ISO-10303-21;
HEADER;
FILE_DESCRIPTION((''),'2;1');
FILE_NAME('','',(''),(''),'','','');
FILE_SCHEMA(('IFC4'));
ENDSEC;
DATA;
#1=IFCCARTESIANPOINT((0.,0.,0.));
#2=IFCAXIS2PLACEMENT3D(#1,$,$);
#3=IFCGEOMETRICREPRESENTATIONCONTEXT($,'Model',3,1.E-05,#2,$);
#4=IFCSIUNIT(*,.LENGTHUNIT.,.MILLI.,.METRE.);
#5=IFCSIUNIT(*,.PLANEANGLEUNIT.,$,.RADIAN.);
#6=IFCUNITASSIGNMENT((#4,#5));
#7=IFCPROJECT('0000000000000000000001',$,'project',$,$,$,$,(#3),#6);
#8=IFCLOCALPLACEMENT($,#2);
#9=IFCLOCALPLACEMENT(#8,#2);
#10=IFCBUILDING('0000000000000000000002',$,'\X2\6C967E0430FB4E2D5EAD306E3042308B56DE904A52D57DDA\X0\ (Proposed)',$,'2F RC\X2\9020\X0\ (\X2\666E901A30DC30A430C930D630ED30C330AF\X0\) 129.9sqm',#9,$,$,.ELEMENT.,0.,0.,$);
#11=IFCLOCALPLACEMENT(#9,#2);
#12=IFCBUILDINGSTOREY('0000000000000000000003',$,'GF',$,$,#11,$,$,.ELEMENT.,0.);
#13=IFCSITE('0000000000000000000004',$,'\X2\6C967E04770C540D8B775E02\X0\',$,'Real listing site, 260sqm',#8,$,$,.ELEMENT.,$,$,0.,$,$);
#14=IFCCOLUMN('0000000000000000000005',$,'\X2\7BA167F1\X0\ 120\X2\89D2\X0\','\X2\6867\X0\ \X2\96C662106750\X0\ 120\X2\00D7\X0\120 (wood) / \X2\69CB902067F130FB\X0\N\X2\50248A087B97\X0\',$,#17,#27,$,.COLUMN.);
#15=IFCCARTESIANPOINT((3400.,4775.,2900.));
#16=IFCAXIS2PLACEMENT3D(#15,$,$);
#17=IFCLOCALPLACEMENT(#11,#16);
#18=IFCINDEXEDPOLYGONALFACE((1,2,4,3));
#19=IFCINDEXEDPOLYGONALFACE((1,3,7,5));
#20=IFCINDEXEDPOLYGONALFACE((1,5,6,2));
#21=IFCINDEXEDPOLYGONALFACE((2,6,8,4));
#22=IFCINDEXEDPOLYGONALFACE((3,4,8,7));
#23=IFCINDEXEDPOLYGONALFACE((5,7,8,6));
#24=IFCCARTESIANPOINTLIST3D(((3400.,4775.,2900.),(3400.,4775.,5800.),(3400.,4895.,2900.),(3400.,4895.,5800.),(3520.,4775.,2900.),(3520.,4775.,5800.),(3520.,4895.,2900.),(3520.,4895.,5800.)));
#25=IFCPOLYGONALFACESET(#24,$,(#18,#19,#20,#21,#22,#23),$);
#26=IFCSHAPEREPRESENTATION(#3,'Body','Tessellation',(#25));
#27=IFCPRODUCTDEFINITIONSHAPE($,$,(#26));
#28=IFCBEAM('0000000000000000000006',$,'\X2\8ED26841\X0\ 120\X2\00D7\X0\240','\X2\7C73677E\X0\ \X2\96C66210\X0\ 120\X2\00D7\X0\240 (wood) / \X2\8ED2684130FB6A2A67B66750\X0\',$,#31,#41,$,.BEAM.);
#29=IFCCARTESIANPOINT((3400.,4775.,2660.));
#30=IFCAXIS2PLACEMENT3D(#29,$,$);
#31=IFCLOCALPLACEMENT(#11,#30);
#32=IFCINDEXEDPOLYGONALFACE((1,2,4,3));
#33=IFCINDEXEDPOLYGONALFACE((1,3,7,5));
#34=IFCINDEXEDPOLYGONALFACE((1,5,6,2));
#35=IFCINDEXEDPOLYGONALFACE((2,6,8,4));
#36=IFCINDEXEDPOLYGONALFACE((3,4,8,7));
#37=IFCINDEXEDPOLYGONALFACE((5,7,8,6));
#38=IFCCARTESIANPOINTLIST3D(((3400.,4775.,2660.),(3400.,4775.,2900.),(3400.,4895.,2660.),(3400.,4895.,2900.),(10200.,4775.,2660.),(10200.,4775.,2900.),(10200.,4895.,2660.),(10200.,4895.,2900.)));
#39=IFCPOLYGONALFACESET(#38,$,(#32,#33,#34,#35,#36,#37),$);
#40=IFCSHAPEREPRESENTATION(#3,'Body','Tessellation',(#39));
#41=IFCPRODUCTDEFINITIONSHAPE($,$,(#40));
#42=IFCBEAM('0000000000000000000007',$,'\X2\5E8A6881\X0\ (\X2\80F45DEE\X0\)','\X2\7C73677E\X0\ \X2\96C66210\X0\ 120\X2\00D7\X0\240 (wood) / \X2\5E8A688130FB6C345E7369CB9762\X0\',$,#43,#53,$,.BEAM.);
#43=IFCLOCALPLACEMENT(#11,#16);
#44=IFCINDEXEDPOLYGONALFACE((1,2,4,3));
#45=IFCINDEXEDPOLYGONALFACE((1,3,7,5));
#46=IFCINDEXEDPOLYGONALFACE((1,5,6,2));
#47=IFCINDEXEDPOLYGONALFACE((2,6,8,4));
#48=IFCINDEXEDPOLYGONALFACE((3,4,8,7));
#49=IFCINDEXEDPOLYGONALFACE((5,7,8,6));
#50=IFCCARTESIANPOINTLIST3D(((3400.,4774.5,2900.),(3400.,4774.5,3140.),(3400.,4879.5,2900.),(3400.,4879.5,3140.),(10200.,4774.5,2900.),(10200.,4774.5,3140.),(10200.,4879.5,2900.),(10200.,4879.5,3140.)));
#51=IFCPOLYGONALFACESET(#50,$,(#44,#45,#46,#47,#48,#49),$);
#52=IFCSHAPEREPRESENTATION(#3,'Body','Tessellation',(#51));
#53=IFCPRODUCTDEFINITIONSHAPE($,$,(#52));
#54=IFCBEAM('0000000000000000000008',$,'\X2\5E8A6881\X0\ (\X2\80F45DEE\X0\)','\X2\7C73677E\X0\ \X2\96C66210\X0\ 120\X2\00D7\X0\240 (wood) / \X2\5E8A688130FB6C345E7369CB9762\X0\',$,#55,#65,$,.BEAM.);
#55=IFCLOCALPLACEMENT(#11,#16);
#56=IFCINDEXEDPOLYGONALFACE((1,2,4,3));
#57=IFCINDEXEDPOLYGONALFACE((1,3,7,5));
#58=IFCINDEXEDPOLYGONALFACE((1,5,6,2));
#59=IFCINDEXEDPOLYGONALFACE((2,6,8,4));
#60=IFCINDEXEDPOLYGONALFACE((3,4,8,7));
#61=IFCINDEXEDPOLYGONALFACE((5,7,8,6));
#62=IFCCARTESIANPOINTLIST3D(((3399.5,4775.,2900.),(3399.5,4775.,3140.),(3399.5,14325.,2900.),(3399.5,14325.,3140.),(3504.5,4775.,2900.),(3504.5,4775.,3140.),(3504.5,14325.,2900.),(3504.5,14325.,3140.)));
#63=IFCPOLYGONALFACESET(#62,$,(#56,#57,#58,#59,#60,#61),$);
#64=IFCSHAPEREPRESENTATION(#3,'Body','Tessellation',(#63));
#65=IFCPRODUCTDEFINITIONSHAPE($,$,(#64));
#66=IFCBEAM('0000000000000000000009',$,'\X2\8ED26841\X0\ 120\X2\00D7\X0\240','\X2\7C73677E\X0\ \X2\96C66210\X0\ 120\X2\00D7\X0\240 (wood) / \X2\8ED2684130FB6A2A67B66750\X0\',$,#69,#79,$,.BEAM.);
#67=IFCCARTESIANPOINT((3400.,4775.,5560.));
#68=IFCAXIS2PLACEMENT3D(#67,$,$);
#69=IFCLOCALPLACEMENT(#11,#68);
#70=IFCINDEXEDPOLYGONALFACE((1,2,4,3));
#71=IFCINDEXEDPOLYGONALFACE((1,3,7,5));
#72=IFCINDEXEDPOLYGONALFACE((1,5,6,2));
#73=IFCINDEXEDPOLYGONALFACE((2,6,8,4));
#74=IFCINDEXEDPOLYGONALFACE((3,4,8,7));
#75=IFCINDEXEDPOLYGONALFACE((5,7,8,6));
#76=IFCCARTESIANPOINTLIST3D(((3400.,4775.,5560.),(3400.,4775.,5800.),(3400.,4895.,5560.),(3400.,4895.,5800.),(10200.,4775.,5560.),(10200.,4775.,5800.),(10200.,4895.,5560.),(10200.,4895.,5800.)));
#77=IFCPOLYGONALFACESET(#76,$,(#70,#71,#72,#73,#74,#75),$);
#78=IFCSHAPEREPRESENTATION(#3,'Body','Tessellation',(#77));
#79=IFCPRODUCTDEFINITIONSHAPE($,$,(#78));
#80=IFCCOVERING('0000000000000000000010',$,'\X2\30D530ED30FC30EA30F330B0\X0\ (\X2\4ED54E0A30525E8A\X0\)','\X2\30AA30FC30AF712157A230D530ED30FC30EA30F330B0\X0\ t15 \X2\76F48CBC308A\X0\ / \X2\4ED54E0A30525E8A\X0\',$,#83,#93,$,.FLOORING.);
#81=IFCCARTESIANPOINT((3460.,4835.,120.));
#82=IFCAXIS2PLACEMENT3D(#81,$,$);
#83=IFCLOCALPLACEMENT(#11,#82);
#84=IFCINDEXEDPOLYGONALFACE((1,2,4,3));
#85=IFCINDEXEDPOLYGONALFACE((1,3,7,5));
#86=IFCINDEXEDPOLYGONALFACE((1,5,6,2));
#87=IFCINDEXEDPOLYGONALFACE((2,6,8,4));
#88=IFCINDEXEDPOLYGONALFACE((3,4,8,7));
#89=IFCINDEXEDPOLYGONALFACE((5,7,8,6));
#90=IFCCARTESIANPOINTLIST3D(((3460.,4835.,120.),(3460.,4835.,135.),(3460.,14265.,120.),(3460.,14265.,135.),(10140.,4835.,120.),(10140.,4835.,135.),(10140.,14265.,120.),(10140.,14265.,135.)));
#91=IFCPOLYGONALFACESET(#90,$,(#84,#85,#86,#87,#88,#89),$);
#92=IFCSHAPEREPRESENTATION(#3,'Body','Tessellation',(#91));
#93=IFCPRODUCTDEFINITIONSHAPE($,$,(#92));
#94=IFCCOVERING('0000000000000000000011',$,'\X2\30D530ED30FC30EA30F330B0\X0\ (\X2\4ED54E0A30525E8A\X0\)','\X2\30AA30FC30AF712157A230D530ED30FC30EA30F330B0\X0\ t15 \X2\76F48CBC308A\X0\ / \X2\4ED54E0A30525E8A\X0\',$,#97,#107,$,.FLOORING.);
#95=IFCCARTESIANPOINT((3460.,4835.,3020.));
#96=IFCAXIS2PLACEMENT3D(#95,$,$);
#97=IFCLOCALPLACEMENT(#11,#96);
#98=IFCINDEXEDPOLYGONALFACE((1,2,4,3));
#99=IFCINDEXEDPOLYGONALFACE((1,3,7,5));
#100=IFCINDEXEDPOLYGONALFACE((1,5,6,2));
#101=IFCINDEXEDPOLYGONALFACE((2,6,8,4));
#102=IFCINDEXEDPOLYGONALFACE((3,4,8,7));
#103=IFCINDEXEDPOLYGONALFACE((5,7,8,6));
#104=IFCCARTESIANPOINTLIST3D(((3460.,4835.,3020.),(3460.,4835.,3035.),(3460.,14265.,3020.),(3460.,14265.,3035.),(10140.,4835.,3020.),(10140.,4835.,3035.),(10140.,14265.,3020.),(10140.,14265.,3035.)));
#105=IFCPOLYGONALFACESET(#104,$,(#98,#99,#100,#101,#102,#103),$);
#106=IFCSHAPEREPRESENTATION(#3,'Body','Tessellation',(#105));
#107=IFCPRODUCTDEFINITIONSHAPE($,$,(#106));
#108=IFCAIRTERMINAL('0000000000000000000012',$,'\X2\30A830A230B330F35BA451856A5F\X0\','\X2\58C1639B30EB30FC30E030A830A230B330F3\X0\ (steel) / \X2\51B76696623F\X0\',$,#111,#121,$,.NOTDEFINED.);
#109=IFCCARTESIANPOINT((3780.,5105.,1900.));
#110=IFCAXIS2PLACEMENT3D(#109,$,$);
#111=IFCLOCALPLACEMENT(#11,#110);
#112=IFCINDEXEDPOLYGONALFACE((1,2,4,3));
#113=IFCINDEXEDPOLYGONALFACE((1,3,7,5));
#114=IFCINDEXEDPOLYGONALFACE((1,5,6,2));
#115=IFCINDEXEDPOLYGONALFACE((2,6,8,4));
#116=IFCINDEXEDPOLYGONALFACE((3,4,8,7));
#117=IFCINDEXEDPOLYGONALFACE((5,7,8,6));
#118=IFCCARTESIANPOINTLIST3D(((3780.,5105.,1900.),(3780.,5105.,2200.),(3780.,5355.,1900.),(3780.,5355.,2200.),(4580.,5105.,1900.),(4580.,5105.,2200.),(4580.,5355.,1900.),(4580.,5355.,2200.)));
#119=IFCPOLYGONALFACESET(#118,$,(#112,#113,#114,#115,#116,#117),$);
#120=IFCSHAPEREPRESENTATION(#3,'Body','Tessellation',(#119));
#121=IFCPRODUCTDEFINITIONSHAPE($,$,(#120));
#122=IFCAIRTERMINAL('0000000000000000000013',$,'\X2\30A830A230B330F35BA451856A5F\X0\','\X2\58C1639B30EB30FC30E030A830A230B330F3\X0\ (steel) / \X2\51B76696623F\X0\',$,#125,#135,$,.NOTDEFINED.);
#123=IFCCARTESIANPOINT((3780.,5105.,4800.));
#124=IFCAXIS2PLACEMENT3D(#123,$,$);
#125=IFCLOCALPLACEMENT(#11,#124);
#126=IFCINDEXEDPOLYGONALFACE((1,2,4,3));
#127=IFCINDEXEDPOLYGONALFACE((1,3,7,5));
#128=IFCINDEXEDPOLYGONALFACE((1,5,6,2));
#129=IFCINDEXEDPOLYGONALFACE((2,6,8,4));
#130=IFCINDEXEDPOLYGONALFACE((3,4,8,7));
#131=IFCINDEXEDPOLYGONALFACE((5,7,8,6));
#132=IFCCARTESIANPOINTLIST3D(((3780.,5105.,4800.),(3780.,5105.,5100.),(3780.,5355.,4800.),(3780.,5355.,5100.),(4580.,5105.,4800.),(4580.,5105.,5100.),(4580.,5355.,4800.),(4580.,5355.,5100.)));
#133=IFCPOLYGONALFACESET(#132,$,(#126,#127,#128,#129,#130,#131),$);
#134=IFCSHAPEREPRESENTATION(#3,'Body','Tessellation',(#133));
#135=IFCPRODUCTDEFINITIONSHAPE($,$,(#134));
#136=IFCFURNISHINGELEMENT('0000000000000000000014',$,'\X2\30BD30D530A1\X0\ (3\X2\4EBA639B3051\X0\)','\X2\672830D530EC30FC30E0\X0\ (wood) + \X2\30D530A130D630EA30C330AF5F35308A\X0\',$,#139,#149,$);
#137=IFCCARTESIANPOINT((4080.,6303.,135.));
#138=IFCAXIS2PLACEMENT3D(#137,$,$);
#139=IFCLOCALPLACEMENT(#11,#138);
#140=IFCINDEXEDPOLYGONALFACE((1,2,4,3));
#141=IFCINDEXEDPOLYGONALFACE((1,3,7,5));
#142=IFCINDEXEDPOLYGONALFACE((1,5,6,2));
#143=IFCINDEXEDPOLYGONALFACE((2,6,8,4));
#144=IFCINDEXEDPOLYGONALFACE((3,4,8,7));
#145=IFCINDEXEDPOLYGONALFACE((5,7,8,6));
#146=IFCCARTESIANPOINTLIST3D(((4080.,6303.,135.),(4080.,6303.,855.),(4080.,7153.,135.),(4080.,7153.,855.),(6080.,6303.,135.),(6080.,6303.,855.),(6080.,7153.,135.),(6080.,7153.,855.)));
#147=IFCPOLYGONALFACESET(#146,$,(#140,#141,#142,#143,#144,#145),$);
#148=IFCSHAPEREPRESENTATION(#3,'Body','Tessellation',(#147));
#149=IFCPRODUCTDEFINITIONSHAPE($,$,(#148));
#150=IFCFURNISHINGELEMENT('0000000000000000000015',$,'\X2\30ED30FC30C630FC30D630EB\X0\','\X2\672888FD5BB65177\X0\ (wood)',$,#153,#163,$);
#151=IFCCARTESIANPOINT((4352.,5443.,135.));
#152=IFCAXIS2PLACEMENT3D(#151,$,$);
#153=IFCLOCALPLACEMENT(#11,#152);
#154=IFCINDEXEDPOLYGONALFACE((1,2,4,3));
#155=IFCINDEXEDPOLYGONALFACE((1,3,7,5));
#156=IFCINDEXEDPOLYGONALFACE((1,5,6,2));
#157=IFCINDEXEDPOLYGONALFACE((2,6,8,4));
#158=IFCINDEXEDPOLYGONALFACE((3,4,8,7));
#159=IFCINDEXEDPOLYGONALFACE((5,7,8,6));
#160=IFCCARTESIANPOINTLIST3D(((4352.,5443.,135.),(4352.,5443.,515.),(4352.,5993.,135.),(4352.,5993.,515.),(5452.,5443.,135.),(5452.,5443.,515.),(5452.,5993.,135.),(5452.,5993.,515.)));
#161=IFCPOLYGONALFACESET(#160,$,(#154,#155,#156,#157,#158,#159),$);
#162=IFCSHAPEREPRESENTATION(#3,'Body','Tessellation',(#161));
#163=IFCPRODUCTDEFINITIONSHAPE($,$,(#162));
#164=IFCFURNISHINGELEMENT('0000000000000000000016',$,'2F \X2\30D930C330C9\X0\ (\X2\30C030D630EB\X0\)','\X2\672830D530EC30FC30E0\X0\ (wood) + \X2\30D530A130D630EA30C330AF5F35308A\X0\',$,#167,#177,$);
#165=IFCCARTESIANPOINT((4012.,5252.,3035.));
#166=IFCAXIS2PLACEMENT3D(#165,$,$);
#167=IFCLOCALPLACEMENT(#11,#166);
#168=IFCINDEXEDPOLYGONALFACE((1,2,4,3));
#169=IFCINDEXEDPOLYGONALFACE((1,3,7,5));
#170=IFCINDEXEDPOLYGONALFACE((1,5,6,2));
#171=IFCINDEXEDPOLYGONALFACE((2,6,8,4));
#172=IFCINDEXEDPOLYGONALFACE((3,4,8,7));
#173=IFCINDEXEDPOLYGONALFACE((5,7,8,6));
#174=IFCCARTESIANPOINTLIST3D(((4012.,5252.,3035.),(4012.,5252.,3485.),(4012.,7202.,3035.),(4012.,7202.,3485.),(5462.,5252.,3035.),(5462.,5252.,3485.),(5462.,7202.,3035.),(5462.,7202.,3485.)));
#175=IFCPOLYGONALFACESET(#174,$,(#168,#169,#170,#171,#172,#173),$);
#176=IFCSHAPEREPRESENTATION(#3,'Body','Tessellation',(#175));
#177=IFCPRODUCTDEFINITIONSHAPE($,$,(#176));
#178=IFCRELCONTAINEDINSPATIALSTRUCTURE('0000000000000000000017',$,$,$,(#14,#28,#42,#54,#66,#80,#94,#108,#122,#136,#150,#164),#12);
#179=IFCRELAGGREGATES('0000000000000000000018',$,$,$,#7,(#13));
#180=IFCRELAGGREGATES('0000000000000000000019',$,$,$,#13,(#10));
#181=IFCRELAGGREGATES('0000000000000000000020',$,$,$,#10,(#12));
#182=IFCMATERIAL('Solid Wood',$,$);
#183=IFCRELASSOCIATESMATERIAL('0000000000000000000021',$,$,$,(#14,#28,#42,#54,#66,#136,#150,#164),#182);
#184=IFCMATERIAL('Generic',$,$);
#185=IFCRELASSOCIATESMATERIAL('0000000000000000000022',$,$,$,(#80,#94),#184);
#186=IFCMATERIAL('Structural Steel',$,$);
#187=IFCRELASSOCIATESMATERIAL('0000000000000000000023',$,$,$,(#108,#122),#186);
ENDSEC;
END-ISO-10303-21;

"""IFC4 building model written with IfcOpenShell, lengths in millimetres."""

from ifc_helpers import new_model, si_unit, frame, frame_2d, origin, place, context, project, spatial, rectangle, extrude, material, element, save


model = new_model("IFC4")

# Units and contexts
model_context = context("Model", 3, precision=1e-05, world=origin())
ifc_project = project(units=[si_unit("LENGTHUNIT", "METRE", prefix="MILLI"), si_unit("PLANEANGLEUNIT", "RADIAN")], contexts=[model_context])

# Site, building, storey
site_placement = place(None, origin())
site = spatial("IfcSite", under=ifc_project, at=site_placement, Name="沖縄県名護市", ObjectType="Real listing site, 260sqm", CompositionType="ELEMENT", RefElevation=0.0)
building_placement = place(site_placement, origin())
building = spatial("IfcBuilding", under=site, at=building_placement, Name="沖縄・中庭のある回遊動線 (Proposed)", ObjectType="2F RC造 (普通ボイドブロック) 129.9sqm", CompositionType="ELEMENT", ElevationOfRefHeight=0.0, ElevationOfTerrain=0.0)
storey_placement = place(building_placement, origin())
storey = spatial("IfcBuildingStorey", under=building, at=storey_placement, Name="GF", CompositionType="ELEMENT", Elevation=0.0)

# Column
ifc_material_1 = material(Name="Solid Wood")
column_1_placement = place(storey_placement, frame((3400.0, 4775.0, 2900.0)))
element("IfcColumn", 1, at=column_1_placement, inside=storey, material=ifc_material_1, Name="管柱 120角", Description="桧 集成材 120×120 (wood) / 構造柱・N値計算", PredefinedType="COLUMN", context=model_context, shape_type="SweptSolid", body=[
    extrude(rectangle(XDim=120.0, YDim=120.0, at=frame_2d((60.0, 60.0))), frame((3400.0, 4775.0, 2900.0)), (0.0, 0.0, 1.0), 2900.0),
])

# Beams
beam_1_placement = place(storey_placement, frame((3400.0, 4775.0, 2660.0)))
element("IfcBeam", 2, at=beam_1_placement, inside=storey, material=ifc_material_1, Name="軒桁 120×240", Description="米松 集成 120×240 (wood) / 軒桁・横架材", PredefinedType="BEAM", context=model_context, shape_type="SweptSolid", body=[
    extrude(rectangle(XDim=6800.0, YDim=120.0, at=frame_2d((3400.0, 60.0))), frame((3400.0, 4775.0, 2660.0)), (0.0, 0.0, 1.0), 240.0),
])
beam_2_placement = place(storey_placement, frame((3400.0, 4775.0, 2900.0)))
element("IfcBeam", 3, at=beam_2_placement, inside=storey, material=ifc_material_1, Name="床梁 (胴差)", Description="米松 集成 120×240 (wood) / 床梁・水平構面", PredefinedType="BEAM", context=model_context, shape_type="SweptSolid", body=[
    extrude(rectangle(XDim=6800.0, YDim=105.0, at=frame_2d((3400.0, 52.0))), frame((3400.0, 4775.0, 2900.0)), (0.0, 0.0, 1.0), 240.0),
])
beam_3_placement = place(storey_placement, frame((3400.0, 4775.0, 2900.0)))
element("IfcBeam", 4, at=beam_3_placement, inside=storey, material=ifc_material_1, Name="床梁 (胴差)", Description="米松 集成 120×240 (wood) / 床梁・水平構面", PredefinedType="BEAM", context=model_context, shape_type="SweptSolid", body=[
    extrude(rectangle(XDim=105.0, YDim=9550.0, at=frame_2d((52.0, 4775.0))), frame((3400.0, 4775.0, 2900.0)), (0.0, 0.0, 1.0), 240.0),
])
beam_4_placement = place(storey_placement, frame((3400.0, 4775.0, 5560.0)))
element("IfcBeam", 5, at=beam_4_placement, inside=storey, material=ifc_material_1, Name="軒桁 120×240", Description="米松 集成 120×240 (wood) / 軒桁・横架材", PredefinedType="BEAM", context=model_context, shape_type="SweptSolid", body=[
    extrude(rectangle(XDim=6800.0, YDim=120.0, at=frame_2d((3400.0, 60.0))), frame((3400.0, 4775.0, 5560.0)), (0.0, 0.0, 1.0), 240.0),
])

# Coverings
ifc_material_2 = material(Name="Generic")
covering_1_placement = place(storey_placement, frame((3460.0, 4835.0, 120.0)))
element("IfcCovering", 6, at=covering_1_placement, inside=storey, material=ifc_material_2, Name="フローリング (仕上げ床)", Description="オーク無垢フローリング t15 直貼り / 仕上げ床", PredefinedType="FLOORING", context=model_context, shape_type="SweptSolid", body=[
    extrude(rectangle(XDim=6680.0, YDim=9430.0, at=frame_2d((3340.0, 4715.0))), frame((3460.0, 4835.0, 120.0)), (0.0, 0.0, 1.0), 15.0),
])
covering_2_placement = place(storey_placement, frame((3460.0, 4835.0, 3020.0)))
element("IfcCovering", 7, at=covering_2_placement, inside=storey, material=ifc_material_2, Name="フローリング (仕上げ床)", Description="オーク無垢フローリング t15 直貼り / 仕上げ床", PredefinedType="FLOORING", context=model_context, shape_type="SweptSolid", body=[
    extrude(rectangle(XDim=6680.0, YDim=9430.0, at=frame_2d((3340.0, 4715.0))), frame((3460.0, 4835.0, 3020.0)), (0.0, 0.0, 1.0), 15.0),
])

# Air terminals
ifc_material_3 = material(Name="Structural Steel")
air_terminal_1_placement = place(storey_placement, frame((3780.0, 5105.0, 1900.0)))
element("IfcAirTerminal", 8, at=air_terminal_1_placement, inside=storey, material=ifc_material_3, Name="エアコン室内機", Description="壁掛ルームエアコン (steel) / 冷暖房", PredefinedType="NOTDEFINED", context=model_context, shape_type="SweptSolid", body=[
    extrude(rectangle(XDim=800.0, YDim=250.0, at=frame_2d((400.0, 125.0))), frame((3780.0, 5105.0, 1900.0)), (0.0, 0.0, 1.0), 300.0),
])
air_terminal_2_placement = place(storey_placement, frame((3780.0, 5105.0, 4800.0)))
element("IfcAirTerminal", 9, at=air_terminal_2_placement, inside=storey, material=ifc_material_3, Name="エアコン室内機", Description="壁掛ルームエアコン (steel) / 冷暖房", PredefinedType="NOTDEFINED", context=model_context, shape_type="SweptSolid", body=[
    extrude(rectangle(XDim=800.0, YDim=250.0, at=frame_2d((400.0, 125.0))), frame((3780.0, 5105.0, 4800.0)), (0.0, 0.0, 1.0), 300.0),
])

# Furnishing elements
furnishing_1_placement = place(storey_placement, frame((4080.0, 6303.0, 135.0)))
element("IfcFurnishingElement", 10, at=furnishing_1_placement, inside=storey, material=ifc_material_1, Name="ソファ (3人掛け)", Description="木フレーム (wood) + ファブリック張り", context=model_context, shape_type="SweptSolid", body=[
    extrude(rectangle(XDim=2000.0, YDim=850.0, at=frame_2d((1000.0, 425.0))), frame((4080.0, 6303.0, 135.0)), (0.0, 0.0, 1.0), 720.0),
])
furnishing_2_placement = place(storey_placement, frame((4352.0, 5443.0, 135.0)))
element("IfcFurnishingElement", 11, at=furnishing_2_placement, inside=storey, material=ifc_material_1, Name="ローテーブル", Description="木製家具 (wood)", context=model_context, shape_type="SweptSolid", body=[
    extrude(rectangle(XDim=1100.0, YDim=550.0, at=frame_2d((550.0, 275.0))), frame((4352.0, 5443.0, 135.0)), (0.0, 0.0, 1.0), 380.0),
])
furnishing_3_placement = place(storey_placement, frame((4012.0, 5252.0, 3035.0)))
element("IfcFurnishingElement", 12, at=furnishing_3_placement, inside=storey, material=ifc_material_1, Name="2F ベッド (ダブル)", Description="木フレーム (wood) + ファブリック張り", context=model_context, shape_type="SweptSolid", body=[
    extrude(rectangle(XDim=1450.0, YDim=1950.0, at=frame_2d((725.0, 975.0))), frame((4012.0, 5252.0, 3035.0)), (0.0, 0.0, 1.0), 450.0),
])

save(model, "model.ifc")
